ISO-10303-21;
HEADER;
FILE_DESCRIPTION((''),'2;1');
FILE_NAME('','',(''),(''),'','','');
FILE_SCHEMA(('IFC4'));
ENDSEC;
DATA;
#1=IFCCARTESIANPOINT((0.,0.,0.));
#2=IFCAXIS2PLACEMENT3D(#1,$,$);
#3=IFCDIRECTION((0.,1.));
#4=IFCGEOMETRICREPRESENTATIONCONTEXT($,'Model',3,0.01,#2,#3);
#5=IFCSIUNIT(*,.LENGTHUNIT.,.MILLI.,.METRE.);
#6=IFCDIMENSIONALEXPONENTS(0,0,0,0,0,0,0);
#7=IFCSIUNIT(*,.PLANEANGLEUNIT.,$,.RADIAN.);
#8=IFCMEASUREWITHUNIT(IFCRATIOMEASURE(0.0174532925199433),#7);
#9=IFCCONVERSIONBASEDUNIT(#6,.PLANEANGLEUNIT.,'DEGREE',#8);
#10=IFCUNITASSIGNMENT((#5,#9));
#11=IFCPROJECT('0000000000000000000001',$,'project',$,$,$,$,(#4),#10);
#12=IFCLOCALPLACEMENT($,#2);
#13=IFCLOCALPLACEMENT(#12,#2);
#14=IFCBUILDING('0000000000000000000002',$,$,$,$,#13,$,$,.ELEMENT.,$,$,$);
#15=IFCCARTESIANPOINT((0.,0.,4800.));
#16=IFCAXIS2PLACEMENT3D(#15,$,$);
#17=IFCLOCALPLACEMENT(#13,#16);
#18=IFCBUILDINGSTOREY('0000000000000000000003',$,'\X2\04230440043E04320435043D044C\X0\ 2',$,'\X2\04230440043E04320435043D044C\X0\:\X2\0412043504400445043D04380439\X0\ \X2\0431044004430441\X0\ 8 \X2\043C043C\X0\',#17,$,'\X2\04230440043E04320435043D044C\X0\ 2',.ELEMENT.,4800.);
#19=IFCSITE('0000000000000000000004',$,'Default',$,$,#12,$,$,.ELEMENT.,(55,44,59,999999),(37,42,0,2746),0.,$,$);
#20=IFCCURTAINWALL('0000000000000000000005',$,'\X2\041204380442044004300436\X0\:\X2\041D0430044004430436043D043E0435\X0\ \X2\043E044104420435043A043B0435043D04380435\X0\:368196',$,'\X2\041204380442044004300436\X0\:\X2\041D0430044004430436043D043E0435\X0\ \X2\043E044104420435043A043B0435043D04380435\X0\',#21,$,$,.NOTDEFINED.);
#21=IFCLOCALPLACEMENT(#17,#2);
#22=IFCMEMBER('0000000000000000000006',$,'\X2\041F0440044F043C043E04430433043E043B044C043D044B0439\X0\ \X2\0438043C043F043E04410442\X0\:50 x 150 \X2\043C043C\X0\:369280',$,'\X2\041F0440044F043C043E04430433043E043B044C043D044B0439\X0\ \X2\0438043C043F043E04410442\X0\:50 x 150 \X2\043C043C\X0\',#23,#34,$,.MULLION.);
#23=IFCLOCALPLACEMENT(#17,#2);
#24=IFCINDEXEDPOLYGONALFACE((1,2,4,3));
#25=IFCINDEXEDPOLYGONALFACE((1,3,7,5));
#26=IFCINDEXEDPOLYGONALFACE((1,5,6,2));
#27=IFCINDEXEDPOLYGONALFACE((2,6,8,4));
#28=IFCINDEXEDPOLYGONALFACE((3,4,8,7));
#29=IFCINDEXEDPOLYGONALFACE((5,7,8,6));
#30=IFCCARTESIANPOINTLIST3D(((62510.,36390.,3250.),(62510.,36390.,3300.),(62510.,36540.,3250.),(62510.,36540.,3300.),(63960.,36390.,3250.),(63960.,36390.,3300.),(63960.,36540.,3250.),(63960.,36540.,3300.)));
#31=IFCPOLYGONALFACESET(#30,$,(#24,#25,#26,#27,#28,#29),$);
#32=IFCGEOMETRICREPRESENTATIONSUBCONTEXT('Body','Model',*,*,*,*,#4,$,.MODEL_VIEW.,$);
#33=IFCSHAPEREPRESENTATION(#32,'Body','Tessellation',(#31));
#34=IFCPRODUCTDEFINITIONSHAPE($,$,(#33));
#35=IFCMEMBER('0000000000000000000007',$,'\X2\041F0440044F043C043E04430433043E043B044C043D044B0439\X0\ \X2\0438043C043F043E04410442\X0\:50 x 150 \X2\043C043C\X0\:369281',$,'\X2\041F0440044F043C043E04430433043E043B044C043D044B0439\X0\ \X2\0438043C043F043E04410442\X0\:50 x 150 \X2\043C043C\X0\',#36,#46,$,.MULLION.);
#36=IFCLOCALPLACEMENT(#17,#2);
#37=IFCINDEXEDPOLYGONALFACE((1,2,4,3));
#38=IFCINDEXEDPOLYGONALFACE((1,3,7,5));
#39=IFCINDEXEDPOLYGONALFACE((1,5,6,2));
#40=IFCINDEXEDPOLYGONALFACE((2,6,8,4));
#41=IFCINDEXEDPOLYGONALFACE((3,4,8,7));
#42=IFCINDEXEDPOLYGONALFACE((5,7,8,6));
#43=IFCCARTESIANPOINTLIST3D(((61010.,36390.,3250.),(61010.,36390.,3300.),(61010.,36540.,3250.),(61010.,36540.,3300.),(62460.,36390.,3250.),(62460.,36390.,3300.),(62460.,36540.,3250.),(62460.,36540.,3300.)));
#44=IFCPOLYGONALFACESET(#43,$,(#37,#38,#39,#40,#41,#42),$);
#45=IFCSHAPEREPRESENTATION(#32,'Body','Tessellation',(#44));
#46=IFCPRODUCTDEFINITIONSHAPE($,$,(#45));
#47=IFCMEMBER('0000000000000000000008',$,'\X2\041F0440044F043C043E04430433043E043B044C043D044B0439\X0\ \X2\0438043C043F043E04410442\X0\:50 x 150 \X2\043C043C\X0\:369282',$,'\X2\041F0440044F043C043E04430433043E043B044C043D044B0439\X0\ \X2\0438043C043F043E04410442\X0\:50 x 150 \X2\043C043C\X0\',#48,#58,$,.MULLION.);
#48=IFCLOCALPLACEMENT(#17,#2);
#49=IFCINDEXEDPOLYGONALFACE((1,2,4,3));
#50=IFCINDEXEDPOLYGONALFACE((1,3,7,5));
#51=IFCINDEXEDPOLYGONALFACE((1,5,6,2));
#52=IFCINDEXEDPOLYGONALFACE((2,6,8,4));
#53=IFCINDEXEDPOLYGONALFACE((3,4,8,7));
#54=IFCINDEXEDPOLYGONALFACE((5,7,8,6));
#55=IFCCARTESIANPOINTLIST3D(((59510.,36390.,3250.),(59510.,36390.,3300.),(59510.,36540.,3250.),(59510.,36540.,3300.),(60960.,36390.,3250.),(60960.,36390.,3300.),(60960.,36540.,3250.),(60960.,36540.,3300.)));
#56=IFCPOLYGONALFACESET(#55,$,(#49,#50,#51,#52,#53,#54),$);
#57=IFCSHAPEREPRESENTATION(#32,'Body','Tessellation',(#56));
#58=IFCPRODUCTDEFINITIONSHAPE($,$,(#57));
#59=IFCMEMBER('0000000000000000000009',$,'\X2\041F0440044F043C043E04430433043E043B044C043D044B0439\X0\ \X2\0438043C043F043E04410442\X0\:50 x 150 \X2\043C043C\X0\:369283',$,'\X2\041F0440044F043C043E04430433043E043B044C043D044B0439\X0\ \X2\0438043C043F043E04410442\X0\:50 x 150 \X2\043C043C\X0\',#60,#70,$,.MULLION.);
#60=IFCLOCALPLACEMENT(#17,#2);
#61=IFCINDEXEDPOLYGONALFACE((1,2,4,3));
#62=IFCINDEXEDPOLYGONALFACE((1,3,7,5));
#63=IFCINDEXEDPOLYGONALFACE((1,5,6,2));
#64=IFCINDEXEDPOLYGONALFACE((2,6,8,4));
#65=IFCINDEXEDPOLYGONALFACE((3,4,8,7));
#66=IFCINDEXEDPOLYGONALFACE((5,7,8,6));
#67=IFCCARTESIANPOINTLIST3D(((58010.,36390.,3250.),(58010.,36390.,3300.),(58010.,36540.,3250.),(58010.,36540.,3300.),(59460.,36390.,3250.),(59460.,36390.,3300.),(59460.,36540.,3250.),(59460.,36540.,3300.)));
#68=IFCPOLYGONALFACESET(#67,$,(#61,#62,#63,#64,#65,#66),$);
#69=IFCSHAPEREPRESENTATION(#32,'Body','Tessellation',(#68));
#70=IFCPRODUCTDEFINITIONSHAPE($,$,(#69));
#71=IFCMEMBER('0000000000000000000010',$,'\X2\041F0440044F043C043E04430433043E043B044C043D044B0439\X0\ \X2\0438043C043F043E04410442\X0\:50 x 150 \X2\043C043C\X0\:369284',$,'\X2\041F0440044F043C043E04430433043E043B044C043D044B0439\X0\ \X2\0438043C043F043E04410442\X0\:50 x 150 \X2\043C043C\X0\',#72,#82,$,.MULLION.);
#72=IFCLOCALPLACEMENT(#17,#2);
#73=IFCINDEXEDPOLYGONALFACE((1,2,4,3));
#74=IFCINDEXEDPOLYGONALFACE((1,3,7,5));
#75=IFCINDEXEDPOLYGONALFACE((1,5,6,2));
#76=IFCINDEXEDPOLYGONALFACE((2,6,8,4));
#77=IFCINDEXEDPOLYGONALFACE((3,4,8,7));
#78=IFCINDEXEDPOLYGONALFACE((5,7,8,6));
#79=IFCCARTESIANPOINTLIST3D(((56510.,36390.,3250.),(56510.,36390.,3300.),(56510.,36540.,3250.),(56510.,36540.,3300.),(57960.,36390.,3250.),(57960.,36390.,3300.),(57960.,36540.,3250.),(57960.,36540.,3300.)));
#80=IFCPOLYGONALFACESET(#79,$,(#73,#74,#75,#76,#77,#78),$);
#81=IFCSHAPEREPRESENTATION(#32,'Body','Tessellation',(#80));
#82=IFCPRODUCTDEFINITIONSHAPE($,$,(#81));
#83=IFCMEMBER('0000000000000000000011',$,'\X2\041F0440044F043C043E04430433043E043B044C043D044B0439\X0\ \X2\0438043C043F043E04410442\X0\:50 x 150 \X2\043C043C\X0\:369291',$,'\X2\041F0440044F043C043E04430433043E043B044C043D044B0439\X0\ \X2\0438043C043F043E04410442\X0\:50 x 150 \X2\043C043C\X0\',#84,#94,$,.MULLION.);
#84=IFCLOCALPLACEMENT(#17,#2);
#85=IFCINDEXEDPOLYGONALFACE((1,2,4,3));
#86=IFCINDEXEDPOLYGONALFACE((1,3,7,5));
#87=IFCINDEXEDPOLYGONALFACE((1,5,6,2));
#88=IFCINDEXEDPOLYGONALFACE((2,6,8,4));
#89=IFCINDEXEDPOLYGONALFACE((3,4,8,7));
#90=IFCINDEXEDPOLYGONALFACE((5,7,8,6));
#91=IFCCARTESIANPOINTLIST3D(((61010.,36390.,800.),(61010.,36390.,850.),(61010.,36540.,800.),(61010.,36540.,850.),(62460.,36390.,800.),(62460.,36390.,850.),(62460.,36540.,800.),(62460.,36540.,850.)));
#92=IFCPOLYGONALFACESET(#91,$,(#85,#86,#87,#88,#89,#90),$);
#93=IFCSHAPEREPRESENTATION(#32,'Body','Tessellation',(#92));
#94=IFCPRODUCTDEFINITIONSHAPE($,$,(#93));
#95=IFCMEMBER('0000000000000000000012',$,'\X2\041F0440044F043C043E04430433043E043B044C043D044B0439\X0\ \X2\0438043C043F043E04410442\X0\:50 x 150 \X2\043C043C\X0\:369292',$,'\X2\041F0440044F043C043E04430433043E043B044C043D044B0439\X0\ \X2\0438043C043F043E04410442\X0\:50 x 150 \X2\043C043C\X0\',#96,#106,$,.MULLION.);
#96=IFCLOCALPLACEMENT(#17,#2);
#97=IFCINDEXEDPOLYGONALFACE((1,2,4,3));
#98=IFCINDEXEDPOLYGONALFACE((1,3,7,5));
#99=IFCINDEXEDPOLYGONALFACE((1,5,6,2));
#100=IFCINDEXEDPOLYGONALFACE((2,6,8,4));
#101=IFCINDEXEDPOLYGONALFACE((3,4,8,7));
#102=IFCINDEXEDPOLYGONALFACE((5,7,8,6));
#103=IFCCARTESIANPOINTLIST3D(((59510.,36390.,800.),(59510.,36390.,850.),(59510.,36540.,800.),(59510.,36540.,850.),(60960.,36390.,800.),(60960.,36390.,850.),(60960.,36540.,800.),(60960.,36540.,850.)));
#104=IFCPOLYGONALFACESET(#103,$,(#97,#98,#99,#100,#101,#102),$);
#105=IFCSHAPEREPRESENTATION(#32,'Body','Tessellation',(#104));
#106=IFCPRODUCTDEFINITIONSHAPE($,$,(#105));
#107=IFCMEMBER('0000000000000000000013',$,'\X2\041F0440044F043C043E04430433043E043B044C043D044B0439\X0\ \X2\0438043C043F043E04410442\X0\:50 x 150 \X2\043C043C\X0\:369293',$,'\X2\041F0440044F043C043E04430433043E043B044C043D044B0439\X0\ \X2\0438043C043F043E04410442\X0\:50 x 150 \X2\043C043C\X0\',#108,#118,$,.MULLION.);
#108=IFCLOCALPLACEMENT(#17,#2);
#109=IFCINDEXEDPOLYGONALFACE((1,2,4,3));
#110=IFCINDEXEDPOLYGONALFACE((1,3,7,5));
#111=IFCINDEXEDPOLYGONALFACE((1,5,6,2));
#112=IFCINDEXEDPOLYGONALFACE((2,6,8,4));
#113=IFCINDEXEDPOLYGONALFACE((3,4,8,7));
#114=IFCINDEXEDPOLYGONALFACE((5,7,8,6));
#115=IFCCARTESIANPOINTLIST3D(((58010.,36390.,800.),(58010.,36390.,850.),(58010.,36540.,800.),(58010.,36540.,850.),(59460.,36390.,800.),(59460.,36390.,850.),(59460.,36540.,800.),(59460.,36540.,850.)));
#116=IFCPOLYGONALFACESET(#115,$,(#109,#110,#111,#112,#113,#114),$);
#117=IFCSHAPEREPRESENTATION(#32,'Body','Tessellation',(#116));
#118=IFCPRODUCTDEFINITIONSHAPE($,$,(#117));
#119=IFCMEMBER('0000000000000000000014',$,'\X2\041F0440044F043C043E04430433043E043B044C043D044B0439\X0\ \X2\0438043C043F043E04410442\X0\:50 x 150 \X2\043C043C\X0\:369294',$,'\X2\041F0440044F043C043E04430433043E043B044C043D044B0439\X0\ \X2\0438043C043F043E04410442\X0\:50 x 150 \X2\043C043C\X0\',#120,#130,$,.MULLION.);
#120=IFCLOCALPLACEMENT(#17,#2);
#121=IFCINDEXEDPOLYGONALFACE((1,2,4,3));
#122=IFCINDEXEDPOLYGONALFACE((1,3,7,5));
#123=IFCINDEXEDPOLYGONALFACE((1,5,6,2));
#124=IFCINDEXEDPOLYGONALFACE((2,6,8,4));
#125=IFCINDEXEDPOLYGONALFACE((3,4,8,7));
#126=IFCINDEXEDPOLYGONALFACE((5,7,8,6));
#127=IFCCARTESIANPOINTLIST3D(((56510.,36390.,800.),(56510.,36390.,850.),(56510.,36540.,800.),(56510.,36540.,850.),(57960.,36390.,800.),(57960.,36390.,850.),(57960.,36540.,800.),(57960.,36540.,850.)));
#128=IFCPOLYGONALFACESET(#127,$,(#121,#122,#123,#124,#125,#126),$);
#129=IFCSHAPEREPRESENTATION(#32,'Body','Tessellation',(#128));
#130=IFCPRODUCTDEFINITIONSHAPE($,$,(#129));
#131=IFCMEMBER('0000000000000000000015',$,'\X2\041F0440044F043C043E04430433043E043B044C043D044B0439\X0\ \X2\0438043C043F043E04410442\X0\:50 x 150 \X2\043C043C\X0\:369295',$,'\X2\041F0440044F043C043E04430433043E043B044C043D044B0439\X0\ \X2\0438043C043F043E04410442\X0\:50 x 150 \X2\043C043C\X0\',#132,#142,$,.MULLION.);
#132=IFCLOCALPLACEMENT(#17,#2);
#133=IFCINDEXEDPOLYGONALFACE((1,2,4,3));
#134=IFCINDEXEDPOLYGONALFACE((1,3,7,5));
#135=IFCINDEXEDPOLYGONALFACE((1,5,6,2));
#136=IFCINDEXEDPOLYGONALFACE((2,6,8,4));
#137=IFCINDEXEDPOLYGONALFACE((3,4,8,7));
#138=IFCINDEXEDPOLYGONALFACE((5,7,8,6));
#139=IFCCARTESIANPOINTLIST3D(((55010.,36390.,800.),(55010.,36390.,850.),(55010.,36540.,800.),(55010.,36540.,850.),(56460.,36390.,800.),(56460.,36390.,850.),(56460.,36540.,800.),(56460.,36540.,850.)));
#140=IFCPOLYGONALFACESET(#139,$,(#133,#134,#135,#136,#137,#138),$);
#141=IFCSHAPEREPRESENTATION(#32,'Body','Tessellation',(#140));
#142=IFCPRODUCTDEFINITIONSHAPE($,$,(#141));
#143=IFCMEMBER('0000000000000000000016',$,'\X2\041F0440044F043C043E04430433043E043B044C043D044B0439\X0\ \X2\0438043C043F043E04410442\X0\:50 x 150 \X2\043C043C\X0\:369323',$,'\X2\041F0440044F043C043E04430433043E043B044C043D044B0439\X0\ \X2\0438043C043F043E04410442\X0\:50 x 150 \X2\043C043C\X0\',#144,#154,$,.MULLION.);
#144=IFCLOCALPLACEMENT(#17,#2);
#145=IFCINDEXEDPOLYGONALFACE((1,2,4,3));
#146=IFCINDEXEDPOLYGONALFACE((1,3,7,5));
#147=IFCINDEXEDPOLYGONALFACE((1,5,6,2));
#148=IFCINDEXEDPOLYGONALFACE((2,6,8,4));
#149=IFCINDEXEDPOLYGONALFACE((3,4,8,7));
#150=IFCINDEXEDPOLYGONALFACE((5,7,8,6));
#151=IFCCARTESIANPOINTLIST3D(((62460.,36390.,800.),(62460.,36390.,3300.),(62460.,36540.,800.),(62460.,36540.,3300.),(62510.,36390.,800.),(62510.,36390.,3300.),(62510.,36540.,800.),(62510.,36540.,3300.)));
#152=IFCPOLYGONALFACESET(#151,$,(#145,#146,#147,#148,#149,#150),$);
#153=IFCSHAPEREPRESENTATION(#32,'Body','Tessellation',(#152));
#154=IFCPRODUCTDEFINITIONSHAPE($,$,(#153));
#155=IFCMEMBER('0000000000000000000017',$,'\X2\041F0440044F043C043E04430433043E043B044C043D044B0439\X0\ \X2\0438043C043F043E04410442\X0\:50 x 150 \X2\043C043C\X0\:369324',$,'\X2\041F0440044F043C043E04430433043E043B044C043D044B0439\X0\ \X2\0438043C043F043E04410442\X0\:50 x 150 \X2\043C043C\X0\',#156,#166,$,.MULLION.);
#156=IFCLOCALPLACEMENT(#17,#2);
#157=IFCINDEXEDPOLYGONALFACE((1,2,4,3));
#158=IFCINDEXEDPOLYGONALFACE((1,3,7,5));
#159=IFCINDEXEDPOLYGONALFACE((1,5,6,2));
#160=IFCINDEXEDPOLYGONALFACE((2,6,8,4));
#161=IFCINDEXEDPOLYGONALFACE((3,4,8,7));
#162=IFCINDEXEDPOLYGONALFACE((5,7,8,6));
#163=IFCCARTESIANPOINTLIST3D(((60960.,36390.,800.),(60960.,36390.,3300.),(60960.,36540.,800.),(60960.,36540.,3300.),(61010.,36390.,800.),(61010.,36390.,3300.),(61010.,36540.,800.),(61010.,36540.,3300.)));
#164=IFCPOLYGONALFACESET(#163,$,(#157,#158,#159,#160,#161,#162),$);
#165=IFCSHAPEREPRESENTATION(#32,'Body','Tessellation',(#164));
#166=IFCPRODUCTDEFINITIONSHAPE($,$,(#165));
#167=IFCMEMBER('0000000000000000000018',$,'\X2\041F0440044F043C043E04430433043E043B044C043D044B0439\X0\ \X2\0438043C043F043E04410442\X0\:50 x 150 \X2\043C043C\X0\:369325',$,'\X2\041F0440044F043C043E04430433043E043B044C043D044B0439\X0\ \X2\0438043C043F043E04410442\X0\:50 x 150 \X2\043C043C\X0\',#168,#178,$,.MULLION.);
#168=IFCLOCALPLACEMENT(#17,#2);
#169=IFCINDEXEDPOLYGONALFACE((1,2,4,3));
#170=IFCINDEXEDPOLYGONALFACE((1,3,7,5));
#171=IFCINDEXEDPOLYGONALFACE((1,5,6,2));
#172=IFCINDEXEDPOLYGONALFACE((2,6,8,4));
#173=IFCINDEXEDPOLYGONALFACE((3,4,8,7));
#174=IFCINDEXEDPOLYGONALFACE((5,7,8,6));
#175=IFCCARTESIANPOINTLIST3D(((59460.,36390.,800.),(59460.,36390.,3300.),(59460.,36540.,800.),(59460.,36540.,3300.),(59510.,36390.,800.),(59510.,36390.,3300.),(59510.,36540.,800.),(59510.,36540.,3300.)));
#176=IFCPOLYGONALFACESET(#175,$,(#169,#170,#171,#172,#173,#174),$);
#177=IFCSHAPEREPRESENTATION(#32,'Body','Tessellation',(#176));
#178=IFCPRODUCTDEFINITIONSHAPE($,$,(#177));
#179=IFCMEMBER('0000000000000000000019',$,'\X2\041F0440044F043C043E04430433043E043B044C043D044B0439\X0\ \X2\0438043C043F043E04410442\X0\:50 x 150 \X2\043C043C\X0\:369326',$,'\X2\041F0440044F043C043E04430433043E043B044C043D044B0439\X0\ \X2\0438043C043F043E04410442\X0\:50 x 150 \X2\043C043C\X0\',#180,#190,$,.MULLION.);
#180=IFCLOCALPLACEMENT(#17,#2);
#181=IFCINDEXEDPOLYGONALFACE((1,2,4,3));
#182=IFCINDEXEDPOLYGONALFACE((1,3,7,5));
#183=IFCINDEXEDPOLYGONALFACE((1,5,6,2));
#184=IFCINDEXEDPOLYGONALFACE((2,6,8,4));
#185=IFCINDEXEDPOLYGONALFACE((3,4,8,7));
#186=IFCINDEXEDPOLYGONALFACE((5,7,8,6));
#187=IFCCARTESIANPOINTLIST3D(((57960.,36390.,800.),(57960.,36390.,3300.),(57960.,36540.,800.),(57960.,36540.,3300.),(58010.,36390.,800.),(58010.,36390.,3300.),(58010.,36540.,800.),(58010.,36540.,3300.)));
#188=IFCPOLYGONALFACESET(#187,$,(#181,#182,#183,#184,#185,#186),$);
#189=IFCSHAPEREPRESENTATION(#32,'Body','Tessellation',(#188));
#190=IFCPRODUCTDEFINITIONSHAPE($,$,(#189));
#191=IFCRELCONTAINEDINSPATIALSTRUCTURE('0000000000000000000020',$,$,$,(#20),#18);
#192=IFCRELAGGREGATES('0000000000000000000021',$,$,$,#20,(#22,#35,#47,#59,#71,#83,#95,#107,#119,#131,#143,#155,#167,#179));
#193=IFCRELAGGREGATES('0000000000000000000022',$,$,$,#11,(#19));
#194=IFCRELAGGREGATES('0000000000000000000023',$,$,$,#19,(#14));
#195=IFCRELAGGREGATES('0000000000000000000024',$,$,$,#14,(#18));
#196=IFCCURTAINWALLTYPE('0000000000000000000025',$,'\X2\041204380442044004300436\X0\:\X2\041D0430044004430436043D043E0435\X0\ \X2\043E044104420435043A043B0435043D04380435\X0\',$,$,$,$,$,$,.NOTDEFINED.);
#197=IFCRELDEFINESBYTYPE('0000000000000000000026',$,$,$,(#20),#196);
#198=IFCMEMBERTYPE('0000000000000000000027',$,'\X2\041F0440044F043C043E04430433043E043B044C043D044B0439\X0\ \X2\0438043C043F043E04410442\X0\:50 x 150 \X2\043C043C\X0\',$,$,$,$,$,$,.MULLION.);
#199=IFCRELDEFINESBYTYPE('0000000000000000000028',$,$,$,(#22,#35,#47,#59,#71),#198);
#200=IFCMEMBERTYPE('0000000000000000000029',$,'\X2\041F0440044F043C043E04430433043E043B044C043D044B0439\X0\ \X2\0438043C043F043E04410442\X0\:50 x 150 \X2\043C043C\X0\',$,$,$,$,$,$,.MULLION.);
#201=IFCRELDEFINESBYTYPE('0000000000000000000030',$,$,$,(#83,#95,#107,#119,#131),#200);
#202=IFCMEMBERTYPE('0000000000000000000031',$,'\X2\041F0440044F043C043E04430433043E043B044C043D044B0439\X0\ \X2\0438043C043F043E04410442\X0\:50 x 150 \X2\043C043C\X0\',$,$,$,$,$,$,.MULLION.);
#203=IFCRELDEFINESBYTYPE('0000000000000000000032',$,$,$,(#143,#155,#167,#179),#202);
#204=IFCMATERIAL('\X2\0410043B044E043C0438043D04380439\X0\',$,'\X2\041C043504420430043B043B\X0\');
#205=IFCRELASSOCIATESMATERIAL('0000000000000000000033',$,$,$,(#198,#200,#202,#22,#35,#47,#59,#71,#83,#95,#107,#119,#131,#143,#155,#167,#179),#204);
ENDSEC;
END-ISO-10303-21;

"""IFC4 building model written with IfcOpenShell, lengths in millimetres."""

from ifc_helpers import new_model, entity, si_unit, converted_unit, direction, frame, origin, origin_2d_with_axis, place, context, subcontext, project, spatial, rectangle, extrude, source, transform, mapped, material, material_profile, profile_set, profile_usage, type_object, type_shapes, element, aggregate, save


model = new_model("IFC4")

# Units and contexts
model_context = context("Model", 3, precision=0.01, world=origin(), true_north=direction((0.0, 1.0)))
body_context = subcontext(model_context, "Body", "Model", "MODEL_VIEW")
ifc_project = project(units=[si_unit("LENGTHUNIT", "METRE", prefix="MILLI"), converted_unit("PLANEANGLEUNIT", "DEGREE", entity("IfcRatioMeasure", 0.0174532925199433), si_unit("PLANEANGLEUNIT", "RADIAN"), dimensions=[0, 0, 0, 0, 0, 0, 0])], contexts=[model_context])

# Site, building, storey
site_placement = place(None, origin())
site = spatial("IfcSite", under=ifc_project, at=site_placement, Name="Default", CompositionType="ELEMENT", RefLatitude=(55, 44, 59, 999999), RefLongitude=(37, 42, 0, 2746), RefElevation=0.0)
building_placement = place(site_placement, origin())
building = spatial("IfcBuilding", under=site, at=building_placement, CompositionType="ELEMENT")
storey_placement = place(building_placement, frame((0.0, 0.0, 4800.0)))
storey = spatial("IfcBuildingStorey", under=building, at=storey_placement, Name="Уровень 2", ObjectType="Уровень:Верхний брус 8 мм", LongName="Уровень 2", CompositionType="ELEMENT", Elevation=4800.0)

# Curtain wall, members
curtain_wall_type = type_object("IfcCurtainWallType", Name="Витраж:Наружное остекление", PredefinedType="NOTDEFINED")
curtain_wall_placement = place(storey_placement, frame((0.0, 0.0, -4800.0)))
curtain_wall = element("IfcCurtainWall", 1, at=curtain_wall_placement, inside=storey, type_object=curtain_wall_type, Name="Витраж:Наружное остекление:368196", ObjectType="Витраж:Наружное остекление", PredefinedType="NOTDEFINED")
ifc_material_1 = material(Name="Алюминий", Category="Металл")
ifc_material_profile = material_profile(ifc_material_1, rectangle(XDim=150.0, YDim=50.0, at=origin_2d_with_axis()), Name="50 x 150 мм")
ifc_profile_set = profile_set([ifc_material_profile], Name="50 x 150 мм")
ifc_profile_usage_1 = profile_usage(ifc_profile_set)
member_type_1 = type_object("IfcMemberType", Name="Прямоугольный импост:50 x 150 мм", PredefinedType="MULLION", material=ifc_profile_set)
shared_shape_1 = source(origin(), body_context, "Body", "SweptSolid", [
    extrude(rectangle(XDim=150.0, YDim=50.0, at=origin_2d_with_axis()), frame((-25.0, 0.0, -1450.0), z_axis=(0.0, 0.0, 1.0), x_axis=(0.0, -1.0, 0.0)), (0.0, 0.0, 1.0), 1450.0),
])
type_shapes(member_type_1, [shared_shape_1])
member_1_placement = place(storey_placement, frame((62510.0, 36465.0, 3300.0), z_axis=(-1.0, 0.0, 0.0), x_axis=(0.0, 0.0, 1.0)))
member_1 = element("IfcMember", 2, at=member_1_placement, type_object=member_type_1, material=ifc_profile_usage_1, Name="Прямоугольный импост:50 x 150 мм:369280", ObjectType="Прямоугольный импост:50 x 150 мм", PredefinedType="MULLION", context=body_context, shape_type="MappedRepresentation", body=[
    mapped(shared_shape_1, transform((0.0, 0.0, 0.0), scale=1.0)),
])
ifc_profile_usage_2 = profile_usage(ifc_profile_set)
member_2_placement = place(storey_placement, frame((61010.0, 36465.0, 3300.0), z_axis=(-1.0, 0.0, 0.0), x_axis=(0.0, 0.0, 1.0)))
member_2 = element("IfcMember", 3, at=member_2_placement, type_object=member_type_1, material=ifc_profile_usage_2, Name="Прямоугольный импост:50 x 150 мм:369281", ObjectType="Прямоугольный импост:50 x 150 мм", PredefinedType="MULLION", context=body_context, shape_type="MappedRepresentation", body=[
    mapped(shared_shape_1, transform((0.0, 0.0, 0.0), scale=1.0)),
])
ifc_profile_usage_3 = profile_usage(ifc_profile_set)
member_3_placement = place(storey_placement, frame((59510.0, 36465.0, 3300.0), z_axis=(-1.0, 0.0, 0.0), x_axis=(0.0, 0.0, 1.0)))
member_3 = element("IfcMember", 4, at=member_3_placement, type_object=member_type_1, material=ifc_profile_usage_3, Name="Прямоугольный импост:50 x 150 мм:369282", ObjectType="Прямоугольный импост:50 x 150 мм", PredefinedType="MULLION", context=body_context, shape_type="MappedRepresentation", body=[
    mapped(shared_shape_1, transform((0.0, 0.0, 0.0), scale=1.0)),
])
ifc_profile_usage_4 = profile_usage(ifc_profile_set)
member_4_placement = place(storey_placement, frame((58010.0, 36465.0, 3300.0), z_axis=(-1.0, 0.0, 0.0), x_axis=(0.0, 0.0, 1.0)))
member_4 = element("IfcMember", 5, at=member_4_placement, type_object=member_type_1, material=ifc_profile_usage_4, Name="Прямоугольный импост:50 x 150 мм:369283", ObjectType="Прямоугольный импост:50 x 150 мм", PredefinedType="MULLION", context=body_context, shape_type="MappedRepresentation", body=[
    mapped(shared_shape_1, transform((0.0, 0.0, 0.0), scale=1.0)),
])
ifc_profile_usage_5 = profile_usage(ifc_profile_set)
member_5_placement = place(storey_placement, frame((56510.0, 36465.0, 3300.0), z_axis=(-1.0, 0.0, 0.0), x_axis=(0.0, 0.0, 1.0)))
member_5 = element("IfcMember", 6, at=member_5_placement, type_object=member_type_1, material=ifc_profile_usage_5, Name="Прямоугольный импост:50 x 150 мм:369284", ObjectType="Прямоугольный импост:50 x 150 мм", PredefinedType="MULLION", context=body_context, shape_type="MappedRepresentation", body=[
    mapped(shared_shape_1, transform((0.0, 0.0, 0.0), scale=1.0)),
])
ifc_profile_usage_6 = profile_usage(ifc_profile_set)
member_type_2 = type_object("IfcMemberType", Name="Прямоугольный импост:50 x 150 мм", PredefinedType="MULLION", material=ifc_profile_set)
shared_shape_2 = source(origin(), body_context, "Body", "SweptSolid", [
    extrude(rectangle(XDim=150.0, YDim=50.0, at=origin_2d_with_axis()), frame((-25.0, 0.0, -1450.0), z_axis=(0.0, 0.0, 1.0), x_axis=(0.0, -1.0, 0.0)), (0.0, 0.0, 1.0), 1450.0),
])
type_shapes(member_type_2, [shared_shape_2])
member_6_placement = place(storey_placement, frame((62460.0, 36465.0, 800.0), z_axis=(1.0, 0.0, 0.0), x_axis=(0.0, 0.0, -1.0)))
member_6 = element("IfcMember", 7, at=member_6_placement, type_object=member_type_2, material=ifc_profile_usage_6, Name="Прямоугольный импост:50 x 150 мм:369291", ObjectType="Прямоугольный импост:50 x 150 мм", PredefinedType="MULLION", context=body_context, shape_type="MappedRepresentation", body=[
    mapped(shared_shape_2, transform((0.0, 0.0, 0.0), scale=1.0)),
])
ifc_profile_usage_7 = profile_usage(ifc_profile_set)
member_7_placement = place(storey_placement, frame((60960.0, 36465.0, 800.0), z_axis=(1.0, 0.0, 0.0), x_axis=(0.0, 0.0, -1.0)))
member_7 = element("IfcMember", 8, at=member_7_placement, type_object=member_type_2, material=ifc_profile_usage_7, Name="Прямоугольный импост:50 x 150 мм:369292", ObjectType="Прямоугольный импост:50 x 150 мм", PredefinedType="MULLION", context=body_context, shape_type="MappedRepresentation", body=[
    mapped(shared_shape_2, transform((0.0, 0.0, 0.0), scale=1.0)),
])
ifc_profile_usage_8 = profile_usage(ifc_profile_set)
member_8_placement = place(storey_placement, frame((59460.0, 36465.0, 800.0), z_axis=(1.0, 0.0, 0.0), x_axis=(0.0, 0.0, -1.0)))
member_8 = element("IfcMember", 9, at=member_8_placement, type_object=member_type_2, material=ifc_profile_usage_8, Name="Прямоугольный импост:50 x 150 мм:369293", ObjectType="Прямоугольный импост:50 x 150 мм", PredefinedType="MULLION", context=body_context, shape_type="MappedRepresentation", body=[
    mapped(shared_shape_2, transform((0.0, 0.0, 0.0), scale=1.0)),
])
ifc_profile_usage_9 = profile_usage(ifc_profile_set)
member_9_placement = place(storey_placement, frame((57960.0, 36465.0, 800.0), z_axis=(1.0, 0.0, 0.0), x_axis=(0.0, 0.0, -1.0)))
member_9 = element("IfcMember", 10, at=member_9_placement, type_object=member_type_2, material=ifc_profile_usage_9, Name="Прямоугольный импост:50 x 150 мм:369294", ObjectType="Прямоугольный импост:50 x 150 мм", PredefinedType="MULLION", context=body_context, shape_type="MappedRepresentation", body=[
    mapped(shared_shape_2, transform((0.0, 0.0, 0.0), scale=1.0)),
])
ifc_profile_usage_10 = profile_usage(ifc_profile_set)
member_10_placement = place(storey_placement, frame((56460.0, 36465.0, 800.0), z_axis=(1.0, 0.0, 0.0), x_axis=(0.0, 0.0, -1.0)))
member_10 = element("IfcMember", 11, at=member_10_placement, type_object=member_type_2, material=ifc_profile_usage_10, Name="Прямоугольный импост:50 x 150 мм:369295", ObjectType="Прямоугольный импост:50 x 150 мм", PredefinedType="MULLION", context=body_context, shape_type="MappedRepresentation", body=[
    mapped(shared_shape_2, transform((0.0, 0.0, 0.0), scale=1.0)),
])
ifc_profile_usage_11 = profile_usage(ifc_profile_set)
member_type_3 = type_object("IfcMemberType", Name="Прямоугольный импост:50 x 150 мм", PredefinedType="MULLION", material=ifc_profile_set)
shared_shape_3 = source(origin(), body_context, "Body", "SweptSolid", [
    extrude(rectangle(XDim=150.0, YDim=50.0, at=origin_2d_with_axis()), frame((0.0, 0.0, -2500.0), z_axis=(0.0, 0.0, 1.0), x_axis=(0.0, -1.0, 0.0)), (0.0, 0.0, 1.0), 2500.0),
])
type_shapes(member_type_3, [shared_shape_3])
member_11_placement = place(storey_placement, frame((62485.0, 36465.0, 800.0), z_axis=(0.0, 0.0, -1.0), x_axis=(-1.0, 0.0, 0.0)))
member_11 = element("IfcMember", 12, at=member_11_placement, type_object=member_type_3, material=ifc_profile_usage_11, Name="Прямоугольный импост:50 x 150 мм:369323", ObjectType="Прямоугольный импост:50 x 150 мм", PredefinedType="MULLION", context=body_context, shape_type="MappedRepresentation", body=[
    mapped(shared_shape_3, transform((0.0, 0.0, 0.0), scale=1.0)),
])
ifc_profile_usage_12 = profile_usage(ifc_profile_set)
member_12_placement = place(storey_placement, frame((60985.0, 36465.0, 800.0), z_axis=(0.0, 0.0, -1.0), x_axis=(-1.0, 0.0, 0.0)))
member_12 = element("IfcMember", 13, at=member_12_placement, type_object=member_type_3, material=ifc_profile_usage_12, Name="Прямоугольный импост:50 x 150 мм:369324", ObjectType="Прямоугольный импост:50 x 150 мм", PredefinedType="MULLION", context=body_context, shape_type="MappedRepresentation", body=[
    mapped(shared_shape_3, transform((0.0, 0.0, 0.0), scale=1.0)),
])
ifc_profile_usage_13 = profile_usage(ifc_profile_set)
member_13_placement = place(storey_placement, frame((59485.0, 36465.0, 800.0), z_axis=(0.0, 0.0, -1.0), x_axis=(-1.0, 0.0, 0.0)))
member_13 = element("IfcMember", 14, at=member_13_placement, type_object=member_type_3, material=ifc_profile_usage_13, Name="Прямоугольный импост:50 x 150 мм:369325", ObjectType="Прямоугольный импост:50 x 150 мм", PredefinedType="MULLION", context=body_context, shape_type="MappedRepresentation", body=[
    mapped(shared_shape_3, transform((0.0, 0.0, 0.0), scale=1.0)),
])
ifc_profile_usage_14 = profile_usage(ifc_profile_set)
member_14_placement = place(storey_placement, frame((57985.0, 36465.0, 800.0), z_axis=(0.0, 0.0, -1.0), x_axis=(-1.0, 0.0, 0.0)))
member_14 = element("IfcMember", 15, at=member_14_placement, type_object=member_type_3, material=ifc_profile_usage_14, Name="Прямоугольный импост:50 x 150 мм:369326", ObjectType="Прямоугольный импост:50 x 150 мм", PredefinedType="MULLION", context=body_context, shape_type="MappedRepresentation", body=[
    mapped(shared_shape_3, transform((0.0, 0.0, 0.0), scale=1.0)),
])
aggregate(curtain_wall, [member_1, member_2, member_3, member_4, member_5, member_6, member_7, member_8, member_9, member_10, member_11, member_12, member_13, member_14])

save(model, "model.ifc")
